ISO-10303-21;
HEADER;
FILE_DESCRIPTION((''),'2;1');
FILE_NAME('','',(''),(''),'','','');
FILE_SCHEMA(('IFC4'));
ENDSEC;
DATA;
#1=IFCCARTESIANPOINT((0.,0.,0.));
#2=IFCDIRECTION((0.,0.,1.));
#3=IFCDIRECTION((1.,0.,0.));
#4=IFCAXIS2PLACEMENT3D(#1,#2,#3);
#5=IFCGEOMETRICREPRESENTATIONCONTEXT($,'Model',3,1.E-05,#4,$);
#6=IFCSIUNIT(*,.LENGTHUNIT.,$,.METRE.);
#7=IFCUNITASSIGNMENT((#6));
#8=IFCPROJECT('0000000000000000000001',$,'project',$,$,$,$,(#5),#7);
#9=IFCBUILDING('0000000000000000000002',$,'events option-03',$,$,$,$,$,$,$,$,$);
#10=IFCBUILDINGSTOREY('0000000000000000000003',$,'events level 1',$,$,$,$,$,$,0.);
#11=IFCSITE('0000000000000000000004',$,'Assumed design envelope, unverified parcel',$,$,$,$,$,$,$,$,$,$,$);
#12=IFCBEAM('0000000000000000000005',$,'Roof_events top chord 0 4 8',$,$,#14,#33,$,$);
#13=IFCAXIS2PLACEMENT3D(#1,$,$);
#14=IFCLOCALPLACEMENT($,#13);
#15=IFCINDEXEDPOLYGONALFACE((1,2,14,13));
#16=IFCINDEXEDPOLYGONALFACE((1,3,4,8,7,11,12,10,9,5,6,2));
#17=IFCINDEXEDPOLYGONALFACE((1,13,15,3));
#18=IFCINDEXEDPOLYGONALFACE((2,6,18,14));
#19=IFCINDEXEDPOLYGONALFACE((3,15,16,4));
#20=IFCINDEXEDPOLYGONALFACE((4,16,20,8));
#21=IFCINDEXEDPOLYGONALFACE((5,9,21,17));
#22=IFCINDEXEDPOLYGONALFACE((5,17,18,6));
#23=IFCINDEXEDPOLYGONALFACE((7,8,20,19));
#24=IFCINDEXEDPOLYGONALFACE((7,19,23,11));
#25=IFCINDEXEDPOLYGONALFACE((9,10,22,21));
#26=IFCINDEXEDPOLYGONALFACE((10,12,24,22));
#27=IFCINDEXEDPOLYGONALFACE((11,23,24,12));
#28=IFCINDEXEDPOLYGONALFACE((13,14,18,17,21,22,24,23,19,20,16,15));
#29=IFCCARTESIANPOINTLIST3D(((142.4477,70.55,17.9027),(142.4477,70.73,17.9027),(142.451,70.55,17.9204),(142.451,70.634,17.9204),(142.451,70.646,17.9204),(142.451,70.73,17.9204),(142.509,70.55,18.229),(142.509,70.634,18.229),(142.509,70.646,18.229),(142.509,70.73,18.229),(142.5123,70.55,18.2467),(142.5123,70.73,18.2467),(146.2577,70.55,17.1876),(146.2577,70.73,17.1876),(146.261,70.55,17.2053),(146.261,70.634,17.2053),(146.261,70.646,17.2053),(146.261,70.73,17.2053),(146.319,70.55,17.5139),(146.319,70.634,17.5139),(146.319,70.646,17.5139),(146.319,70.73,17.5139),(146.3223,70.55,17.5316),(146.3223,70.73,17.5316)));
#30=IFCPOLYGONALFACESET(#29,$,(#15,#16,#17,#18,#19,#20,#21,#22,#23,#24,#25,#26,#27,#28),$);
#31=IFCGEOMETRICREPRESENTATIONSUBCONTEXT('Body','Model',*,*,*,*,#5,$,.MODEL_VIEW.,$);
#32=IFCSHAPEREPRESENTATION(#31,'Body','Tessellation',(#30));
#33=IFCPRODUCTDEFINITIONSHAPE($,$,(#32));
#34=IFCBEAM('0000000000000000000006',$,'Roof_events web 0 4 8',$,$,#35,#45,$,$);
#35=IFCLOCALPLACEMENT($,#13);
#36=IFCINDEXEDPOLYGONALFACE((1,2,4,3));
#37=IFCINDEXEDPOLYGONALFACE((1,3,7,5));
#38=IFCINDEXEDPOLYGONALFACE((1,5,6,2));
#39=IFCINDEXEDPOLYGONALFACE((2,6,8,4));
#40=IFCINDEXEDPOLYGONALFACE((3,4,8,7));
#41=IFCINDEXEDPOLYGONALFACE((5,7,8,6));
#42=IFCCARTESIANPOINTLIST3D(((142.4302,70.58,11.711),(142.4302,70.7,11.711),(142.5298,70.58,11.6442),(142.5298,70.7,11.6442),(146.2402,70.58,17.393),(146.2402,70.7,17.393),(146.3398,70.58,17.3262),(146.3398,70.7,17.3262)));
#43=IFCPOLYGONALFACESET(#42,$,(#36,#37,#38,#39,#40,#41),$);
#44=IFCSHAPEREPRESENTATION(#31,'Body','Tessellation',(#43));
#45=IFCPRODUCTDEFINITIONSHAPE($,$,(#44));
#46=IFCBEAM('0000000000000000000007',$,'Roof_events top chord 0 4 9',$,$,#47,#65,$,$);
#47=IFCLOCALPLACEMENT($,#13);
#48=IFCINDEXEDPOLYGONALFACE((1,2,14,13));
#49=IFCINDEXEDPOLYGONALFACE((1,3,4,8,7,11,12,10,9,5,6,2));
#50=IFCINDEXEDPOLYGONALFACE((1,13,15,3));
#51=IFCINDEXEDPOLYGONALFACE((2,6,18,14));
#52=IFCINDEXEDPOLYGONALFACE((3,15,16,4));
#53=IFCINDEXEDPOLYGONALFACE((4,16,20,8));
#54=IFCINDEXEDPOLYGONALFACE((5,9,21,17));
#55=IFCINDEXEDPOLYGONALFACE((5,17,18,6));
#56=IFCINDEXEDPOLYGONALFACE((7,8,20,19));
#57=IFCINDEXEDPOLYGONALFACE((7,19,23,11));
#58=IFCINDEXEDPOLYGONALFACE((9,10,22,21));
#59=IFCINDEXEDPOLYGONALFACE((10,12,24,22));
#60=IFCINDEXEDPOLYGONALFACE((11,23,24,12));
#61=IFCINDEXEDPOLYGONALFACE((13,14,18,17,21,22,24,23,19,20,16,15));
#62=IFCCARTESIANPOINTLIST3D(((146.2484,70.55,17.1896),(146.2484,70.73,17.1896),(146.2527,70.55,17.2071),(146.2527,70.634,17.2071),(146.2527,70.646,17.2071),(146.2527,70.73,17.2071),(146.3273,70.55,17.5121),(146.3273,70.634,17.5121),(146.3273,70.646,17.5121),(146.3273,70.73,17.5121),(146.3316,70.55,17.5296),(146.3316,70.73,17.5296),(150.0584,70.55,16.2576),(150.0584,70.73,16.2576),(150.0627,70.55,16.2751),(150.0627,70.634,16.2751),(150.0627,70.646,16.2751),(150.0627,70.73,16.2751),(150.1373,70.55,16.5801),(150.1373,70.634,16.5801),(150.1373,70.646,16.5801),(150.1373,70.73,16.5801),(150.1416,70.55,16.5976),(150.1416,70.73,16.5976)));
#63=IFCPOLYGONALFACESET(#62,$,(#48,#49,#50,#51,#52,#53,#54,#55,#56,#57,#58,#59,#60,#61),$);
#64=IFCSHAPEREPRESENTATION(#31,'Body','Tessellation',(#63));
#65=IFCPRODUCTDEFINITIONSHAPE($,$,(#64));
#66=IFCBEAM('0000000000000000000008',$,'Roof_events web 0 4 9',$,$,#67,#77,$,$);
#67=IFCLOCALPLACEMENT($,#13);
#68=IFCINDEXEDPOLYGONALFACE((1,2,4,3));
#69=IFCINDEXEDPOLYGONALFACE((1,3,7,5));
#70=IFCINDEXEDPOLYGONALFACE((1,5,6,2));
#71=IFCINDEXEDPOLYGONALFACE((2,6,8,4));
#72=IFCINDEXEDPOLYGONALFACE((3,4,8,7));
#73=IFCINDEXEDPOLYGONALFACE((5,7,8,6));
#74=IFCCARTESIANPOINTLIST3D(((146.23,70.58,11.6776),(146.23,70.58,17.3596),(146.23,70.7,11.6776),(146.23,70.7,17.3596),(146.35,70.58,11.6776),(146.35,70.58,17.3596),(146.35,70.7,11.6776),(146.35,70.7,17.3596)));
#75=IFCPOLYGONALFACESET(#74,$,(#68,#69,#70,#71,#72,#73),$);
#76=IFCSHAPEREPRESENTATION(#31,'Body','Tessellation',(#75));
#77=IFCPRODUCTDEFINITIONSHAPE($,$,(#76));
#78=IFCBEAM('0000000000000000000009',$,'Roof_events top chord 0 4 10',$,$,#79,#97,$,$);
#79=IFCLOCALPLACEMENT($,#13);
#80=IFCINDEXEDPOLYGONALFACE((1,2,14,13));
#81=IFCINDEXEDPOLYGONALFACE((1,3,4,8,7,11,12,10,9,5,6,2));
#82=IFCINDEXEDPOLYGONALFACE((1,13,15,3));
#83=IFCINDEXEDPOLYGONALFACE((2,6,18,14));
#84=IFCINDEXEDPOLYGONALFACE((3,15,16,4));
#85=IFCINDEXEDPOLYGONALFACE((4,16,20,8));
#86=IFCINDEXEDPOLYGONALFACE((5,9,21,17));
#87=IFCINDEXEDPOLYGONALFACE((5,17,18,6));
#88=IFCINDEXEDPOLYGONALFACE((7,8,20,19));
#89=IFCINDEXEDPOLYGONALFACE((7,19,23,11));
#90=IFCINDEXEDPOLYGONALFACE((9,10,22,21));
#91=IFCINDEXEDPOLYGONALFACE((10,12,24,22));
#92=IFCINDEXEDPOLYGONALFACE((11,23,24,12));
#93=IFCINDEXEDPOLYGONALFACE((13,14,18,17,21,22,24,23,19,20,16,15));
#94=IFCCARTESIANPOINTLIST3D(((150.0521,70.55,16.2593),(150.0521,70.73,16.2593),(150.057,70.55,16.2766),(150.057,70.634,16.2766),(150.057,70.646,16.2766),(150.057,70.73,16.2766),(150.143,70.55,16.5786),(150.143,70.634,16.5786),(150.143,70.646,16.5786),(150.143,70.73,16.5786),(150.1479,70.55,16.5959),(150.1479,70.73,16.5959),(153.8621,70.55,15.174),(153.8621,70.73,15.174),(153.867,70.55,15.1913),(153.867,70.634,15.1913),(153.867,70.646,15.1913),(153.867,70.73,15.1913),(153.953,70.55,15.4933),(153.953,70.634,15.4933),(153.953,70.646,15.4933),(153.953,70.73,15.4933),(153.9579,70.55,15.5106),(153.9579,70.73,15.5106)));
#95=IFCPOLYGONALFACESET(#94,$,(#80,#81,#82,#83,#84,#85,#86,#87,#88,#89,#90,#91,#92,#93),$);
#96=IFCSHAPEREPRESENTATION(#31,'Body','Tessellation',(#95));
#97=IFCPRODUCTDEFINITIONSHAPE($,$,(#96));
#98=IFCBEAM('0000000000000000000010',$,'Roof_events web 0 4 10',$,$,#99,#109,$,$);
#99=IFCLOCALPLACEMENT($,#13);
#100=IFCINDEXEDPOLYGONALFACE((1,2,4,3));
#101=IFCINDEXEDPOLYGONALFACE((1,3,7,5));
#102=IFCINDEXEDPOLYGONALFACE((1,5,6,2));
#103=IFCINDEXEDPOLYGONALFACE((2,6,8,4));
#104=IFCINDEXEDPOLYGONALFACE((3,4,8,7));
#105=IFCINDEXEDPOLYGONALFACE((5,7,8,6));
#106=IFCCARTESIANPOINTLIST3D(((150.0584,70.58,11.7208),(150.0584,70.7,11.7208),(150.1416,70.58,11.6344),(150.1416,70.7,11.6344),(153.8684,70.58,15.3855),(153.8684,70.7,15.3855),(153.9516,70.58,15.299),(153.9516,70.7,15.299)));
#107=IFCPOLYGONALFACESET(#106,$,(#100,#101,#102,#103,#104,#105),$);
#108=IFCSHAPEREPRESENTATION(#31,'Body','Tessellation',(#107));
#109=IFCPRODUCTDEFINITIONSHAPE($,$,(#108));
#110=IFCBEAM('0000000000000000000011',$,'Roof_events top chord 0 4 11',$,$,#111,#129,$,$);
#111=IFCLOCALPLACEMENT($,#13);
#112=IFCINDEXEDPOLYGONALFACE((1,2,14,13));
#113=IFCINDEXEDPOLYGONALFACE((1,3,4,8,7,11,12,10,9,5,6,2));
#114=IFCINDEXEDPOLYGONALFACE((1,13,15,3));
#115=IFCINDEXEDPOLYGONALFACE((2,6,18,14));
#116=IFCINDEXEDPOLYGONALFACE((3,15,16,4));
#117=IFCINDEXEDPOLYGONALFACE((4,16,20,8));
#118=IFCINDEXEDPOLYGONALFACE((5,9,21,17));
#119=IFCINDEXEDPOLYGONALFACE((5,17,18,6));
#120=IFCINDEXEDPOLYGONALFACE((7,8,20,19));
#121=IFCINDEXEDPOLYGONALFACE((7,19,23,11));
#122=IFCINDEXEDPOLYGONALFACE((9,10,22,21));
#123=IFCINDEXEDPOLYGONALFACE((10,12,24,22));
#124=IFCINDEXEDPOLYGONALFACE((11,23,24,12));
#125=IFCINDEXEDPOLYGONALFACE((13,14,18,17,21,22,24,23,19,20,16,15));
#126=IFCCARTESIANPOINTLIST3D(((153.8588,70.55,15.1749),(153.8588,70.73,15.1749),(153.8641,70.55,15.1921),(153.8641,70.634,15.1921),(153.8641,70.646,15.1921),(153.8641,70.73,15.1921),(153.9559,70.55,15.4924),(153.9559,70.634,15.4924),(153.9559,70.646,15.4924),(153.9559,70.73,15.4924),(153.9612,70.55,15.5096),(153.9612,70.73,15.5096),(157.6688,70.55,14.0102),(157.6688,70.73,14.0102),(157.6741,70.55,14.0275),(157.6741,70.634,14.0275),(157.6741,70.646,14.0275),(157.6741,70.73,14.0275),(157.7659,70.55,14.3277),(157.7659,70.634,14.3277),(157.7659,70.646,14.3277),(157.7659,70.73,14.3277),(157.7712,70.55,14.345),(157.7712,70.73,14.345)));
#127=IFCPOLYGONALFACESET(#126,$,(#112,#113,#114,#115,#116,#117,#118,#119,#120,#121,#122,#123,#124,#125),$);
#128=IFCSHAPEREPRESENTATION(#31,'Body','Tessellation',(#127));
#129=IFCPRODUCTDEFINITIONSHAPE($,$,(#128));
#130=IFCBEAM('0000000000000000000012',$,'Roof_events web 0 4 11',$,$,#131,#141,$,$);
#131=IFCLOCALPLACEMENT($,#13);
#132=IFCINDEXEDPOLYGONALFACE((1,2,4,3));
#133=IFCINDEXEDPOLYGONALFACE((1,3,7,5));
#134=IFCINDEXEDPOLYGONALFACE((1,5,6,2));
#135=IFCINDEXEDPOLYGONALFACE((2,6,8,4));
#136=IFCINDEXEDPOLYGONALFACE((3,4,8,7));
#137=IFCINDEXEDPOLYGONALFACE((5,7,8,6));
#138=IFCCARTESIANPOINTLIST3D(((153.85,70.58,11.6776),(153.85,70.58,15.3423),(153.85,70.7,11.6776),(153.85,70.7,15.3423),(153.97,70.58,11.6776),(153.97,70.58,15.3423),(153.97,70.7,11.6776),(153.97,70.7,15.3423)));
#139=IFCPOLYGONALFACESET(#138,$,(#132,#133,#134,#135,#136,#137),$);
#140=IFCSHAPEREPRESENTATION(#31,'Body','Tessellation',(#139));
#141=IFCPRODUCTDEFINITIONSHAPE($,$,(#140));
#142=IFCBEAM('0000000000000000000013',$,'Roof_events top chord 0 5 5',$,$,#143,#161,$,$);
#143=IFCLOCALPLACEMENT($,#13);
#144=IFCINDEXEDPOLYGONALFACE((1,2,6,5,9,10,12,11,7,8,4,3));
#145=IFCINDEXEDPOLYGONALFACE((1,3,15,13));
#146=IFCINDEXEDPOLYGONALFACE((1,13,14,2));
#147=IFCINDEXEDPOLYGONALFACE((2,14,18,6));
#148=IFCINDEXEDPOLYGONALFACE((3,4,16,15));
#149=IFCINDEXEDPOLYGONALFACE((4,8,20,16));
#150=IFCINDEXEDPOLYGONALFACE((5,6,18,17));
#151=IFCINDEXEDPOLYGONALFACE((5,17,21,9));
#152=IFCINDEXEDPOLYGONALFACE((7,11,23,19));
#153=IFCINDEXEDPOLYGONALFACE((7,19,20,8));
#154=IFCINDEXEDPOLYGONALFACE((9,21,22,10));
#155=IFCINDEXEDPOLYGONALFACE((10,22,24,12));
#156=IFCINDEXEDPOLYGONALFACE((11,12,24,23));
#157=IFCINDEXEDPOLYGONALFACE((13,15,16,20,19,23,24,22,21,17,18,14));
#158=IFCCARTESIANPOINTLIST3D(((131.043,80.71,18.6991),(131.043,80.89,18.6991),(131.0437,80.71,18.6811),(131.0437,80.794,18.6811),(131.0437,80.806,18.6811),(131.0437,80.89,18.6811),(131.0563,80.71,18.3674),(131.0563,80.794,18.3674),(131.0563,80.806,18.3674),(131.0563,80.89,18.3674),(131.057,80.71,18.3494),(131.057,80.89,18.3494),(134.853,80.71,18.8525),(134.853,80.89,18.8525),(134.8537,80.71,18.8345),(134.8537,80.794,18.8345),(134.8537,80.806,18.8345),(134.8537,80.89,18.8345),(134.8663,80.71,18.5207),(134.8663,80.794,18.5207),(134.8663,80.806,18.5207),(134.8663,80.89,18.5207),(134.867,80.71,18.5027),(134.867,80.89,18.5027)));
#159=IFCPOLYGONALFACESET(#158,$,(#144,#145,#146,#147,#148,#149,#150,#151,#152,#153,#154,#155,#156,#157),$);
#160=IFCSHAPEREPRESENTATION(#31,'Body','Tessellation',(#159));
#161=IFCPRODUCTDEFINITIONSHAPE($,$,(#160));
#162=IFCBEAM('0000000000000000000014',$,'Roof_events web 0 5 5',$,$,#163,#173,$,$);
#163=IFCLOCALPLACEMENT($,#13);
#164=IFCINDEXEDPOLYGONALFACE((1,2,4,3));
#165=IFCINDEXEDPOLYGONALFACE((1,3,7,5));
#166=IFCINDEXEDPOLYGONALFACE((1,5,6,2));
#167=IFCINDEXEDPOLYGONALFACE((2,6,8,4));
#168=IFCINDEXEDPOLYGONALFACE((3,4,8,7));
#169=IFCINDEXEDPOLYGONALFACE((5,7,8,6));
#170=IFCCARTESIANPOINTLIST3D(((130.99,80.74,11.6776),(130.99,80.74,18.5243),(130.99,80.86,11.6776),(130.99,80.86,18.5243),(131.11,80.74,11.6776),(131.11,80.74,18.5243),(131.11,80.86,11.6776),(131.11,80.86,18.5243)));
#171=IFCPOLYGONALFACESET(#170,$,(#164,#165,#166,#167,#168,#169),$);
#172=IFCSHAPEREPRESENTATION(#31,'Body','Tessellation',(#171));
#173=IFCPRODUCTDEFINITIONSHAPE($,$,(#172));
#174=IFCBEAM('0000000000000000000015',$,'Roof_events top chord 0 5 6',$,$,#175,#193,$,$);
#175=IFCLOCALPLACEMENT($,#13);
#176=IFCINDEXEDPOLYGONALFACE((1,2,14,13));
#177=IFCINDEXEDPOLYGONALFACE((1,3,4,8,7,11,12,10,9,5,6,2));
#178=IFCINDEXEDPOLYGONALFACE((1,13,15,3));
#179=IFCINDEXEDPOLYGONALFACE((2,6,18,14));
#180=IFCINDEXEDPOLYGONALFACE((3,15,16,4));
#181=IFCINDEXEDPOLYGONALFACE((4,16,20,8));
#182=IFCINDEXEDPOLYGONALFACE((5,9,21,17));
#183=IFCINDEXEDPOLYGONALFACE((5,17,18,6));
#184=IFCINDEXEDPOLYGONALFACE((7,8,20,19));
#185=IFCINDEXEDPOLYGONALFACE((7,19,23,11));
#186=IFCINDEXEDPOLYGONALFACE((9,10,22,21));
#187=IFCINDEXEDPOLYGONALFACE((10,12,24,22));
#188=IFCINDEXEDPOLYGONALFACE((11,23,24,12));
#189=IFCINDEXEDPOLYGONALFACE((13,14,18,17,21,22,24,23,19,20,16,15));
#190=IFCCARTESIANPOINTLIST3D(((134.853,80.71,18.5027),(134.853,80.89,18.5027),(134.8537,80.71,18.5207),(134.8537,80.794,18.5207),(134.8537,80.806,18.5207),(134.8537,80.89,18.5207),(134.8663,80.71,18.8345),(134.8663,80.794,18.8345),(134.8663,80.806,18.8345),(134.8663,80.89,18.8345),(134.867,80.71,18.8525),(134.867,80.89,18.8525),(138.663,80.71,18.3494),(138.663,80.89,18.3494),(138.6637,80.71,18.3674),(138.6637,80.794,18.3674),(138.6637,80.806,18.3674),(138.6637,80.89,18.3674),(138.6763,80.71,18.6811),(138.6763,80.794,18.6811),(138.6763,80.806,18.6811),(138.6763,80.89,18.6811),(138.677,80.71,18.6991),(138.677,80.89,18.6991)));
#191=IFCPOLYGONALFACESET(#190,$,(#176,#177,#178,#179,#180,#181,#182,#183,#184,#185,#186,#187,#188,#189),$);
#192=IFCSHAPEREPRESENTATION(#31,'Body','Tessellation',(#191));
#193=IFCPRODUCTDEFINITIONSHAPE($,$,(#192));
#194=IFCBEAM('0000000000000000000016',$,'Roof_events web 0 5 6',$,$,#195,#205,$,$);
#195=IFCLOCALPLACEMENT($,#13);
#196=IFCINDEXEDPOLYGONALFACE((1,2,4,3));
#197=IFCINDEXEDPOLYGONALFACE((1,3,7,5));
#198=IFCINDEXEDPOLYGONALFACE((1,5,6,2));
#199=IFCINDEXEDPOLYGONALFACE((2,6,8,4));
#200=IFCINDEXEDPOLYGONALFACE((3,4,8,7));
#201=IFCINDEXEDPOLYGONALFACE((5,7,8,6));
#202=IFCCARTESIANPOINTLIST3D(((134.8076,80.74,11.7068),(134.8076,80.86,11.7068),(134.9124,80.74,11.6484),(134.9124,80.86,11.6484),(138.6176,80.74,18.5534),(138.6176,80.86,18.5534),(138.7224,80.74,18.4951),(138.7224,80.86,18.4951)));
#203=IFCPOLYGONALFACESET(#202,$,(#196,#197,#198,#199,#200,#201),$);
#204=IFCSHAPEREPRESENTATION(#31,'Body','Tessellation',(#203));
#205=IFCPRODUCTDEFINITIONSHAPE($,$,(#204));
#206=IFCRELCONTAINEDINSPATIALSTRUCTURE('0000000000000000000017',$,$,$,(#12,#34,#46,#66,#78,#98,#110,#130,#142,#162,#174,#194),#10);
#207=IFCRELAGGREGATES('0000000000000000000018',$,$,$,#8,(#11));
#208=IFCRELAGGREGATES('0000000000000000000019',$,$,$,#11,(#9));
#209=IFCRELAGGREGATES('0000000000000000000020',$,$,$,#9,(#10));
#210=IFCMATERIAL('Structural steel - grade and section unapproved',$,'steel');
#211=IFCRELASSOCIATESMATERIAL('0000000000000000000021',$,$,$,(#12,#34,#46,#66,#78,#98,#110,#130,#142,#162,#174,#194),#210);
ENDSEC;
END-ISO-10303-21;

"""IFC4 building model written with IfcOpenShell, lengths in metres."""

from ifc_helpers import new_model, si_unit, frame, origin_with_axes, place, context, subcontext, project, spatial, rectangle, i_section, extrude, material, element, save


model = new_model("IFC4")

# Units and contexts
model_context = context("Model", 3, precision=1e-05, world=origin_with_axes())
body_context = subcontext(model_context, "Body", "Model", "MODEL_VIEW")
ifc_project = project(units=[si_unit("LENGTHUNIT", "METRE")], contexts=[model_context])

# Site, building, storey
site = spatial("IfcSite", under=ifc_project, Name="Assumed design envelope, unverified parcel")
building = spatial("IfcBuilding", under=site, Name="events option-03")
storey = spatial("IfcBuildingStorey", under=building, Name="events level 1", Elevation=0.0)

# Beams
ifc_material = material(Name="Structural steel - grade and section unapproved", Category="steel")
beam_1_placement = place(None, frame((142.48, 70.64, 18.0747), z_axis=(0.982837, 0.0, -0.184478), x_axis=(0.0, 1.0, 0.0)))
element("IfcBeam", 1, at=beam_1_placement, inside=storey, material=ifc_material, Name="Roof_events top chord 0 4 8", context=body_context, shape_type="SweptSolid", body=[
    extrude(i_section(OverallWidth=0.18, OverallDepth=0.35, WebThickness=0.012, FlangeThickness=0.018, FilletRadius=0.0), origin_with_axes(), (0.0, 0.0, 1.0), 3.8765),
])
beam_2_placement = place(None, frame((142.48, 70.64, 11.6776), z_axis=(0.556926, 0.0, 0.830562), x_axis=(0.0, 1.0, 0.0)))
element("IfcBeam", 2, at=beam_2_placement, inside=storey, material=ifc_material, Name="Roof_events web 0 4 8", context=body_context, shape_type="SweptSolid", body=[
    extrude(rectangle(XDim=0.12, YDim=0.12), origin_with_axes(), (0.0, 0.0, 1.0), 6.8411),
])
beam_3_placement = place(None, frame((146.29, 70.64, 17.3596), z_axis=(0.971361, 0.0, -0.237608), x_axis=(0.0, 1.0, 0.0)))
element("IfcBeam", 3, at=beam_3_placement, inside=storey, material=ifc_material, Name="Roof_events top chord 0 4 9", context=body_context, shape_type="SweptSolid", body=[
    extrude(i_section(OverallWidth=0.18, OverallDepth=0.35, WebThickness=0.012, FlangeThickness=0.018, FilletRadius=0.0), origin_with_axes(), (0.0, 0.0, 1.0), 3.9223),
])
beam_4_placement = place(None, frame((146.29, 70.64, 11.6776), z_axis=(0.0, 0.0, 1.0), x_axis=(-1.0, 0.0, 0.0)))
element("IfcBeam", 4, at=beam_4_placement, inside=storey, material=ifc_material, Name="Roof_events web 0 4 9", context=body_context, shape_type="SweptSolid", body=[
    extrude(rectangle(XDim=0.12, YDim=0.12), origin_with_axes(), (0.0, 0.0, 1.0), 5.682),
])
beam_5_placement = place(None, frame((150.1, 70.64, 16.4276), z_axis=(0.961741, 0.0, -0.273961), x_axis=(0.0, 1.0, 0.0)))
element("IfcBeam", 5, at=beam_5_placement, inside=storey, material=ifc_material, Name="Roof_events top chord 0 4 10", context=body_context, shape_type="SweptSolid", body=[
    extrude(i_section(OverallWidth=0.18, OverallDepth=0.35, WebThickness=0.012, FlangeThickness=0.018, FilletRadius=0.0), origin_with_axes(), (0.0, 0.0, 1.0), 3.9616),
])
beam_6_placement = place(None, frame((150.1, 70.64, 11.6776), z_axis=(0.720717, 0.0, 0.693229), x_axis=(0.0, 1.0, 0.0)))
element("IfcBeam", 6, at=beam_6_placement, inside=storey, material=ifc_material, Name="Roof_events web 0 4 10", context=body_context, shape_type="SweptSolid", body=[
    extrude(rectangle(XDim=0.12, YDim=0.12), origin_with_axes(), (0.0, 0.0, 1.0), 5.2864),
])
beam_7_placement = place(None, frame((153.91, 70.64, 15.3423), z_axis=(0.956315, 0.0, -0.292338), x_axis=(0.0, 1.0, 0.0)))
element("IfcBeam", 7, at=beam_7_placement, inside=storey, material=ifc_material, Name="Roof_events top chord 0 4 11", context=body_context, shape_type="SweptSolid", body=[
    extrude(i_section(OverallWidth=0.18, OverallDepth=0.35, WebThickness=0.012, FlangeThickness=0.018, FilletRadius=0.0), origin_with_axes(), (0.0, 0.0, 1.0), 3.984),
])
beam_8_placement = place(None, frame((153.91, 70.64, 11.6776), z_axis=(0.0, 0.0, 1.0), x_axis=(-1.0, 0.0, 0.0)))
element("IfcBeam", 8, at=beam_8_placement, inside=storey, material=ifc_material, Name="Roof_events web 0 4 11", context=body_context, shape_type="SweptSolid", body=[
    extrude(rectangle(XDim=0.12, YDim=0.12), origin_with_axes(), (0.0, 0.0, 1.0), 3.6647),
])
beam_9_placement = place(None, frame((131.05, 80.8, 18.5243), z_axis=(0.999191, 0.0, 0.040213), x_axis=(0.0, 1.0, 0.0)))
element("IfcBeam", 9, at=beam_9_placement, inside=storey, material=ifc_material, Name="Roof_events top chord 0 5 5", context=body_context, shape_type="SweptSolid", body=[
    extrude(i_section(OverallWidth=0.18, OverallDepth=0.35, WebThickness=0.012, FlangeThickness=0.018, FilletRadius=0.0), origin_with_axes(), (0.0, 0.0, 1.0), 3.8131),
])
beam_10_placement = place(None, frame((131.05, 80.8, 11.6776), z_axis=(0.0, 0.0, 1.0), x_axis=(-1.0, 0.0, 0.0)))
element("IfcBeam", 10, at=beam_10_placement, inside=storey, material=ifc_material, Name="Roof_events web 0 5 5", context=body_context, shape_type="SweptSolid", body=[
    extrude(rectangle(XDim=0.12, YDim=0.12), origin_with_axes(), (0.0, 0.0, 1.0), 6.8467),
])
beam_11_placement = place(None, frame((134.86, 80.8, 18.6776), z_axis=(0.999191, 0.0, -0.040212), x_axis=(0.0, 1.0, 0.0)))
element("IfcBeam", 11, at=beam_11_placement, inside=storey, material=ifc_material, Name="Roof_events top chord 0 5 6", context=body_context, shape_type="SweptSolid", body=[
    extrude(i_section(OverallWidth=0.18, OverallDepth=0.35, WebThickness=0.012, FlangeThickness=0.018, FilletRadius=0.0), origin_with_axes(), (0.0, 0.0, 1.0), 3.8131),
])
beam_12_placement = place(None, frame((134.86, 80.8, 11.6776), z_axis=(0.486257, 0.0, 0.873816), x_axis=(0.0, 1.0, 0.0)))
element("IfcBeam", 12, at=beam_12_placement, inside=storey, material=ifc_material, Name="Roof_events web 0 5 6", context=body_context, shape_type="SweptSolid", body=[
    extrude(rectangle(XDim=0.12, YDim=0.12), origin_with_axes(), (0.0, 0.0, 1.0), 7.8354),
])

save(model, "model.ifc")
